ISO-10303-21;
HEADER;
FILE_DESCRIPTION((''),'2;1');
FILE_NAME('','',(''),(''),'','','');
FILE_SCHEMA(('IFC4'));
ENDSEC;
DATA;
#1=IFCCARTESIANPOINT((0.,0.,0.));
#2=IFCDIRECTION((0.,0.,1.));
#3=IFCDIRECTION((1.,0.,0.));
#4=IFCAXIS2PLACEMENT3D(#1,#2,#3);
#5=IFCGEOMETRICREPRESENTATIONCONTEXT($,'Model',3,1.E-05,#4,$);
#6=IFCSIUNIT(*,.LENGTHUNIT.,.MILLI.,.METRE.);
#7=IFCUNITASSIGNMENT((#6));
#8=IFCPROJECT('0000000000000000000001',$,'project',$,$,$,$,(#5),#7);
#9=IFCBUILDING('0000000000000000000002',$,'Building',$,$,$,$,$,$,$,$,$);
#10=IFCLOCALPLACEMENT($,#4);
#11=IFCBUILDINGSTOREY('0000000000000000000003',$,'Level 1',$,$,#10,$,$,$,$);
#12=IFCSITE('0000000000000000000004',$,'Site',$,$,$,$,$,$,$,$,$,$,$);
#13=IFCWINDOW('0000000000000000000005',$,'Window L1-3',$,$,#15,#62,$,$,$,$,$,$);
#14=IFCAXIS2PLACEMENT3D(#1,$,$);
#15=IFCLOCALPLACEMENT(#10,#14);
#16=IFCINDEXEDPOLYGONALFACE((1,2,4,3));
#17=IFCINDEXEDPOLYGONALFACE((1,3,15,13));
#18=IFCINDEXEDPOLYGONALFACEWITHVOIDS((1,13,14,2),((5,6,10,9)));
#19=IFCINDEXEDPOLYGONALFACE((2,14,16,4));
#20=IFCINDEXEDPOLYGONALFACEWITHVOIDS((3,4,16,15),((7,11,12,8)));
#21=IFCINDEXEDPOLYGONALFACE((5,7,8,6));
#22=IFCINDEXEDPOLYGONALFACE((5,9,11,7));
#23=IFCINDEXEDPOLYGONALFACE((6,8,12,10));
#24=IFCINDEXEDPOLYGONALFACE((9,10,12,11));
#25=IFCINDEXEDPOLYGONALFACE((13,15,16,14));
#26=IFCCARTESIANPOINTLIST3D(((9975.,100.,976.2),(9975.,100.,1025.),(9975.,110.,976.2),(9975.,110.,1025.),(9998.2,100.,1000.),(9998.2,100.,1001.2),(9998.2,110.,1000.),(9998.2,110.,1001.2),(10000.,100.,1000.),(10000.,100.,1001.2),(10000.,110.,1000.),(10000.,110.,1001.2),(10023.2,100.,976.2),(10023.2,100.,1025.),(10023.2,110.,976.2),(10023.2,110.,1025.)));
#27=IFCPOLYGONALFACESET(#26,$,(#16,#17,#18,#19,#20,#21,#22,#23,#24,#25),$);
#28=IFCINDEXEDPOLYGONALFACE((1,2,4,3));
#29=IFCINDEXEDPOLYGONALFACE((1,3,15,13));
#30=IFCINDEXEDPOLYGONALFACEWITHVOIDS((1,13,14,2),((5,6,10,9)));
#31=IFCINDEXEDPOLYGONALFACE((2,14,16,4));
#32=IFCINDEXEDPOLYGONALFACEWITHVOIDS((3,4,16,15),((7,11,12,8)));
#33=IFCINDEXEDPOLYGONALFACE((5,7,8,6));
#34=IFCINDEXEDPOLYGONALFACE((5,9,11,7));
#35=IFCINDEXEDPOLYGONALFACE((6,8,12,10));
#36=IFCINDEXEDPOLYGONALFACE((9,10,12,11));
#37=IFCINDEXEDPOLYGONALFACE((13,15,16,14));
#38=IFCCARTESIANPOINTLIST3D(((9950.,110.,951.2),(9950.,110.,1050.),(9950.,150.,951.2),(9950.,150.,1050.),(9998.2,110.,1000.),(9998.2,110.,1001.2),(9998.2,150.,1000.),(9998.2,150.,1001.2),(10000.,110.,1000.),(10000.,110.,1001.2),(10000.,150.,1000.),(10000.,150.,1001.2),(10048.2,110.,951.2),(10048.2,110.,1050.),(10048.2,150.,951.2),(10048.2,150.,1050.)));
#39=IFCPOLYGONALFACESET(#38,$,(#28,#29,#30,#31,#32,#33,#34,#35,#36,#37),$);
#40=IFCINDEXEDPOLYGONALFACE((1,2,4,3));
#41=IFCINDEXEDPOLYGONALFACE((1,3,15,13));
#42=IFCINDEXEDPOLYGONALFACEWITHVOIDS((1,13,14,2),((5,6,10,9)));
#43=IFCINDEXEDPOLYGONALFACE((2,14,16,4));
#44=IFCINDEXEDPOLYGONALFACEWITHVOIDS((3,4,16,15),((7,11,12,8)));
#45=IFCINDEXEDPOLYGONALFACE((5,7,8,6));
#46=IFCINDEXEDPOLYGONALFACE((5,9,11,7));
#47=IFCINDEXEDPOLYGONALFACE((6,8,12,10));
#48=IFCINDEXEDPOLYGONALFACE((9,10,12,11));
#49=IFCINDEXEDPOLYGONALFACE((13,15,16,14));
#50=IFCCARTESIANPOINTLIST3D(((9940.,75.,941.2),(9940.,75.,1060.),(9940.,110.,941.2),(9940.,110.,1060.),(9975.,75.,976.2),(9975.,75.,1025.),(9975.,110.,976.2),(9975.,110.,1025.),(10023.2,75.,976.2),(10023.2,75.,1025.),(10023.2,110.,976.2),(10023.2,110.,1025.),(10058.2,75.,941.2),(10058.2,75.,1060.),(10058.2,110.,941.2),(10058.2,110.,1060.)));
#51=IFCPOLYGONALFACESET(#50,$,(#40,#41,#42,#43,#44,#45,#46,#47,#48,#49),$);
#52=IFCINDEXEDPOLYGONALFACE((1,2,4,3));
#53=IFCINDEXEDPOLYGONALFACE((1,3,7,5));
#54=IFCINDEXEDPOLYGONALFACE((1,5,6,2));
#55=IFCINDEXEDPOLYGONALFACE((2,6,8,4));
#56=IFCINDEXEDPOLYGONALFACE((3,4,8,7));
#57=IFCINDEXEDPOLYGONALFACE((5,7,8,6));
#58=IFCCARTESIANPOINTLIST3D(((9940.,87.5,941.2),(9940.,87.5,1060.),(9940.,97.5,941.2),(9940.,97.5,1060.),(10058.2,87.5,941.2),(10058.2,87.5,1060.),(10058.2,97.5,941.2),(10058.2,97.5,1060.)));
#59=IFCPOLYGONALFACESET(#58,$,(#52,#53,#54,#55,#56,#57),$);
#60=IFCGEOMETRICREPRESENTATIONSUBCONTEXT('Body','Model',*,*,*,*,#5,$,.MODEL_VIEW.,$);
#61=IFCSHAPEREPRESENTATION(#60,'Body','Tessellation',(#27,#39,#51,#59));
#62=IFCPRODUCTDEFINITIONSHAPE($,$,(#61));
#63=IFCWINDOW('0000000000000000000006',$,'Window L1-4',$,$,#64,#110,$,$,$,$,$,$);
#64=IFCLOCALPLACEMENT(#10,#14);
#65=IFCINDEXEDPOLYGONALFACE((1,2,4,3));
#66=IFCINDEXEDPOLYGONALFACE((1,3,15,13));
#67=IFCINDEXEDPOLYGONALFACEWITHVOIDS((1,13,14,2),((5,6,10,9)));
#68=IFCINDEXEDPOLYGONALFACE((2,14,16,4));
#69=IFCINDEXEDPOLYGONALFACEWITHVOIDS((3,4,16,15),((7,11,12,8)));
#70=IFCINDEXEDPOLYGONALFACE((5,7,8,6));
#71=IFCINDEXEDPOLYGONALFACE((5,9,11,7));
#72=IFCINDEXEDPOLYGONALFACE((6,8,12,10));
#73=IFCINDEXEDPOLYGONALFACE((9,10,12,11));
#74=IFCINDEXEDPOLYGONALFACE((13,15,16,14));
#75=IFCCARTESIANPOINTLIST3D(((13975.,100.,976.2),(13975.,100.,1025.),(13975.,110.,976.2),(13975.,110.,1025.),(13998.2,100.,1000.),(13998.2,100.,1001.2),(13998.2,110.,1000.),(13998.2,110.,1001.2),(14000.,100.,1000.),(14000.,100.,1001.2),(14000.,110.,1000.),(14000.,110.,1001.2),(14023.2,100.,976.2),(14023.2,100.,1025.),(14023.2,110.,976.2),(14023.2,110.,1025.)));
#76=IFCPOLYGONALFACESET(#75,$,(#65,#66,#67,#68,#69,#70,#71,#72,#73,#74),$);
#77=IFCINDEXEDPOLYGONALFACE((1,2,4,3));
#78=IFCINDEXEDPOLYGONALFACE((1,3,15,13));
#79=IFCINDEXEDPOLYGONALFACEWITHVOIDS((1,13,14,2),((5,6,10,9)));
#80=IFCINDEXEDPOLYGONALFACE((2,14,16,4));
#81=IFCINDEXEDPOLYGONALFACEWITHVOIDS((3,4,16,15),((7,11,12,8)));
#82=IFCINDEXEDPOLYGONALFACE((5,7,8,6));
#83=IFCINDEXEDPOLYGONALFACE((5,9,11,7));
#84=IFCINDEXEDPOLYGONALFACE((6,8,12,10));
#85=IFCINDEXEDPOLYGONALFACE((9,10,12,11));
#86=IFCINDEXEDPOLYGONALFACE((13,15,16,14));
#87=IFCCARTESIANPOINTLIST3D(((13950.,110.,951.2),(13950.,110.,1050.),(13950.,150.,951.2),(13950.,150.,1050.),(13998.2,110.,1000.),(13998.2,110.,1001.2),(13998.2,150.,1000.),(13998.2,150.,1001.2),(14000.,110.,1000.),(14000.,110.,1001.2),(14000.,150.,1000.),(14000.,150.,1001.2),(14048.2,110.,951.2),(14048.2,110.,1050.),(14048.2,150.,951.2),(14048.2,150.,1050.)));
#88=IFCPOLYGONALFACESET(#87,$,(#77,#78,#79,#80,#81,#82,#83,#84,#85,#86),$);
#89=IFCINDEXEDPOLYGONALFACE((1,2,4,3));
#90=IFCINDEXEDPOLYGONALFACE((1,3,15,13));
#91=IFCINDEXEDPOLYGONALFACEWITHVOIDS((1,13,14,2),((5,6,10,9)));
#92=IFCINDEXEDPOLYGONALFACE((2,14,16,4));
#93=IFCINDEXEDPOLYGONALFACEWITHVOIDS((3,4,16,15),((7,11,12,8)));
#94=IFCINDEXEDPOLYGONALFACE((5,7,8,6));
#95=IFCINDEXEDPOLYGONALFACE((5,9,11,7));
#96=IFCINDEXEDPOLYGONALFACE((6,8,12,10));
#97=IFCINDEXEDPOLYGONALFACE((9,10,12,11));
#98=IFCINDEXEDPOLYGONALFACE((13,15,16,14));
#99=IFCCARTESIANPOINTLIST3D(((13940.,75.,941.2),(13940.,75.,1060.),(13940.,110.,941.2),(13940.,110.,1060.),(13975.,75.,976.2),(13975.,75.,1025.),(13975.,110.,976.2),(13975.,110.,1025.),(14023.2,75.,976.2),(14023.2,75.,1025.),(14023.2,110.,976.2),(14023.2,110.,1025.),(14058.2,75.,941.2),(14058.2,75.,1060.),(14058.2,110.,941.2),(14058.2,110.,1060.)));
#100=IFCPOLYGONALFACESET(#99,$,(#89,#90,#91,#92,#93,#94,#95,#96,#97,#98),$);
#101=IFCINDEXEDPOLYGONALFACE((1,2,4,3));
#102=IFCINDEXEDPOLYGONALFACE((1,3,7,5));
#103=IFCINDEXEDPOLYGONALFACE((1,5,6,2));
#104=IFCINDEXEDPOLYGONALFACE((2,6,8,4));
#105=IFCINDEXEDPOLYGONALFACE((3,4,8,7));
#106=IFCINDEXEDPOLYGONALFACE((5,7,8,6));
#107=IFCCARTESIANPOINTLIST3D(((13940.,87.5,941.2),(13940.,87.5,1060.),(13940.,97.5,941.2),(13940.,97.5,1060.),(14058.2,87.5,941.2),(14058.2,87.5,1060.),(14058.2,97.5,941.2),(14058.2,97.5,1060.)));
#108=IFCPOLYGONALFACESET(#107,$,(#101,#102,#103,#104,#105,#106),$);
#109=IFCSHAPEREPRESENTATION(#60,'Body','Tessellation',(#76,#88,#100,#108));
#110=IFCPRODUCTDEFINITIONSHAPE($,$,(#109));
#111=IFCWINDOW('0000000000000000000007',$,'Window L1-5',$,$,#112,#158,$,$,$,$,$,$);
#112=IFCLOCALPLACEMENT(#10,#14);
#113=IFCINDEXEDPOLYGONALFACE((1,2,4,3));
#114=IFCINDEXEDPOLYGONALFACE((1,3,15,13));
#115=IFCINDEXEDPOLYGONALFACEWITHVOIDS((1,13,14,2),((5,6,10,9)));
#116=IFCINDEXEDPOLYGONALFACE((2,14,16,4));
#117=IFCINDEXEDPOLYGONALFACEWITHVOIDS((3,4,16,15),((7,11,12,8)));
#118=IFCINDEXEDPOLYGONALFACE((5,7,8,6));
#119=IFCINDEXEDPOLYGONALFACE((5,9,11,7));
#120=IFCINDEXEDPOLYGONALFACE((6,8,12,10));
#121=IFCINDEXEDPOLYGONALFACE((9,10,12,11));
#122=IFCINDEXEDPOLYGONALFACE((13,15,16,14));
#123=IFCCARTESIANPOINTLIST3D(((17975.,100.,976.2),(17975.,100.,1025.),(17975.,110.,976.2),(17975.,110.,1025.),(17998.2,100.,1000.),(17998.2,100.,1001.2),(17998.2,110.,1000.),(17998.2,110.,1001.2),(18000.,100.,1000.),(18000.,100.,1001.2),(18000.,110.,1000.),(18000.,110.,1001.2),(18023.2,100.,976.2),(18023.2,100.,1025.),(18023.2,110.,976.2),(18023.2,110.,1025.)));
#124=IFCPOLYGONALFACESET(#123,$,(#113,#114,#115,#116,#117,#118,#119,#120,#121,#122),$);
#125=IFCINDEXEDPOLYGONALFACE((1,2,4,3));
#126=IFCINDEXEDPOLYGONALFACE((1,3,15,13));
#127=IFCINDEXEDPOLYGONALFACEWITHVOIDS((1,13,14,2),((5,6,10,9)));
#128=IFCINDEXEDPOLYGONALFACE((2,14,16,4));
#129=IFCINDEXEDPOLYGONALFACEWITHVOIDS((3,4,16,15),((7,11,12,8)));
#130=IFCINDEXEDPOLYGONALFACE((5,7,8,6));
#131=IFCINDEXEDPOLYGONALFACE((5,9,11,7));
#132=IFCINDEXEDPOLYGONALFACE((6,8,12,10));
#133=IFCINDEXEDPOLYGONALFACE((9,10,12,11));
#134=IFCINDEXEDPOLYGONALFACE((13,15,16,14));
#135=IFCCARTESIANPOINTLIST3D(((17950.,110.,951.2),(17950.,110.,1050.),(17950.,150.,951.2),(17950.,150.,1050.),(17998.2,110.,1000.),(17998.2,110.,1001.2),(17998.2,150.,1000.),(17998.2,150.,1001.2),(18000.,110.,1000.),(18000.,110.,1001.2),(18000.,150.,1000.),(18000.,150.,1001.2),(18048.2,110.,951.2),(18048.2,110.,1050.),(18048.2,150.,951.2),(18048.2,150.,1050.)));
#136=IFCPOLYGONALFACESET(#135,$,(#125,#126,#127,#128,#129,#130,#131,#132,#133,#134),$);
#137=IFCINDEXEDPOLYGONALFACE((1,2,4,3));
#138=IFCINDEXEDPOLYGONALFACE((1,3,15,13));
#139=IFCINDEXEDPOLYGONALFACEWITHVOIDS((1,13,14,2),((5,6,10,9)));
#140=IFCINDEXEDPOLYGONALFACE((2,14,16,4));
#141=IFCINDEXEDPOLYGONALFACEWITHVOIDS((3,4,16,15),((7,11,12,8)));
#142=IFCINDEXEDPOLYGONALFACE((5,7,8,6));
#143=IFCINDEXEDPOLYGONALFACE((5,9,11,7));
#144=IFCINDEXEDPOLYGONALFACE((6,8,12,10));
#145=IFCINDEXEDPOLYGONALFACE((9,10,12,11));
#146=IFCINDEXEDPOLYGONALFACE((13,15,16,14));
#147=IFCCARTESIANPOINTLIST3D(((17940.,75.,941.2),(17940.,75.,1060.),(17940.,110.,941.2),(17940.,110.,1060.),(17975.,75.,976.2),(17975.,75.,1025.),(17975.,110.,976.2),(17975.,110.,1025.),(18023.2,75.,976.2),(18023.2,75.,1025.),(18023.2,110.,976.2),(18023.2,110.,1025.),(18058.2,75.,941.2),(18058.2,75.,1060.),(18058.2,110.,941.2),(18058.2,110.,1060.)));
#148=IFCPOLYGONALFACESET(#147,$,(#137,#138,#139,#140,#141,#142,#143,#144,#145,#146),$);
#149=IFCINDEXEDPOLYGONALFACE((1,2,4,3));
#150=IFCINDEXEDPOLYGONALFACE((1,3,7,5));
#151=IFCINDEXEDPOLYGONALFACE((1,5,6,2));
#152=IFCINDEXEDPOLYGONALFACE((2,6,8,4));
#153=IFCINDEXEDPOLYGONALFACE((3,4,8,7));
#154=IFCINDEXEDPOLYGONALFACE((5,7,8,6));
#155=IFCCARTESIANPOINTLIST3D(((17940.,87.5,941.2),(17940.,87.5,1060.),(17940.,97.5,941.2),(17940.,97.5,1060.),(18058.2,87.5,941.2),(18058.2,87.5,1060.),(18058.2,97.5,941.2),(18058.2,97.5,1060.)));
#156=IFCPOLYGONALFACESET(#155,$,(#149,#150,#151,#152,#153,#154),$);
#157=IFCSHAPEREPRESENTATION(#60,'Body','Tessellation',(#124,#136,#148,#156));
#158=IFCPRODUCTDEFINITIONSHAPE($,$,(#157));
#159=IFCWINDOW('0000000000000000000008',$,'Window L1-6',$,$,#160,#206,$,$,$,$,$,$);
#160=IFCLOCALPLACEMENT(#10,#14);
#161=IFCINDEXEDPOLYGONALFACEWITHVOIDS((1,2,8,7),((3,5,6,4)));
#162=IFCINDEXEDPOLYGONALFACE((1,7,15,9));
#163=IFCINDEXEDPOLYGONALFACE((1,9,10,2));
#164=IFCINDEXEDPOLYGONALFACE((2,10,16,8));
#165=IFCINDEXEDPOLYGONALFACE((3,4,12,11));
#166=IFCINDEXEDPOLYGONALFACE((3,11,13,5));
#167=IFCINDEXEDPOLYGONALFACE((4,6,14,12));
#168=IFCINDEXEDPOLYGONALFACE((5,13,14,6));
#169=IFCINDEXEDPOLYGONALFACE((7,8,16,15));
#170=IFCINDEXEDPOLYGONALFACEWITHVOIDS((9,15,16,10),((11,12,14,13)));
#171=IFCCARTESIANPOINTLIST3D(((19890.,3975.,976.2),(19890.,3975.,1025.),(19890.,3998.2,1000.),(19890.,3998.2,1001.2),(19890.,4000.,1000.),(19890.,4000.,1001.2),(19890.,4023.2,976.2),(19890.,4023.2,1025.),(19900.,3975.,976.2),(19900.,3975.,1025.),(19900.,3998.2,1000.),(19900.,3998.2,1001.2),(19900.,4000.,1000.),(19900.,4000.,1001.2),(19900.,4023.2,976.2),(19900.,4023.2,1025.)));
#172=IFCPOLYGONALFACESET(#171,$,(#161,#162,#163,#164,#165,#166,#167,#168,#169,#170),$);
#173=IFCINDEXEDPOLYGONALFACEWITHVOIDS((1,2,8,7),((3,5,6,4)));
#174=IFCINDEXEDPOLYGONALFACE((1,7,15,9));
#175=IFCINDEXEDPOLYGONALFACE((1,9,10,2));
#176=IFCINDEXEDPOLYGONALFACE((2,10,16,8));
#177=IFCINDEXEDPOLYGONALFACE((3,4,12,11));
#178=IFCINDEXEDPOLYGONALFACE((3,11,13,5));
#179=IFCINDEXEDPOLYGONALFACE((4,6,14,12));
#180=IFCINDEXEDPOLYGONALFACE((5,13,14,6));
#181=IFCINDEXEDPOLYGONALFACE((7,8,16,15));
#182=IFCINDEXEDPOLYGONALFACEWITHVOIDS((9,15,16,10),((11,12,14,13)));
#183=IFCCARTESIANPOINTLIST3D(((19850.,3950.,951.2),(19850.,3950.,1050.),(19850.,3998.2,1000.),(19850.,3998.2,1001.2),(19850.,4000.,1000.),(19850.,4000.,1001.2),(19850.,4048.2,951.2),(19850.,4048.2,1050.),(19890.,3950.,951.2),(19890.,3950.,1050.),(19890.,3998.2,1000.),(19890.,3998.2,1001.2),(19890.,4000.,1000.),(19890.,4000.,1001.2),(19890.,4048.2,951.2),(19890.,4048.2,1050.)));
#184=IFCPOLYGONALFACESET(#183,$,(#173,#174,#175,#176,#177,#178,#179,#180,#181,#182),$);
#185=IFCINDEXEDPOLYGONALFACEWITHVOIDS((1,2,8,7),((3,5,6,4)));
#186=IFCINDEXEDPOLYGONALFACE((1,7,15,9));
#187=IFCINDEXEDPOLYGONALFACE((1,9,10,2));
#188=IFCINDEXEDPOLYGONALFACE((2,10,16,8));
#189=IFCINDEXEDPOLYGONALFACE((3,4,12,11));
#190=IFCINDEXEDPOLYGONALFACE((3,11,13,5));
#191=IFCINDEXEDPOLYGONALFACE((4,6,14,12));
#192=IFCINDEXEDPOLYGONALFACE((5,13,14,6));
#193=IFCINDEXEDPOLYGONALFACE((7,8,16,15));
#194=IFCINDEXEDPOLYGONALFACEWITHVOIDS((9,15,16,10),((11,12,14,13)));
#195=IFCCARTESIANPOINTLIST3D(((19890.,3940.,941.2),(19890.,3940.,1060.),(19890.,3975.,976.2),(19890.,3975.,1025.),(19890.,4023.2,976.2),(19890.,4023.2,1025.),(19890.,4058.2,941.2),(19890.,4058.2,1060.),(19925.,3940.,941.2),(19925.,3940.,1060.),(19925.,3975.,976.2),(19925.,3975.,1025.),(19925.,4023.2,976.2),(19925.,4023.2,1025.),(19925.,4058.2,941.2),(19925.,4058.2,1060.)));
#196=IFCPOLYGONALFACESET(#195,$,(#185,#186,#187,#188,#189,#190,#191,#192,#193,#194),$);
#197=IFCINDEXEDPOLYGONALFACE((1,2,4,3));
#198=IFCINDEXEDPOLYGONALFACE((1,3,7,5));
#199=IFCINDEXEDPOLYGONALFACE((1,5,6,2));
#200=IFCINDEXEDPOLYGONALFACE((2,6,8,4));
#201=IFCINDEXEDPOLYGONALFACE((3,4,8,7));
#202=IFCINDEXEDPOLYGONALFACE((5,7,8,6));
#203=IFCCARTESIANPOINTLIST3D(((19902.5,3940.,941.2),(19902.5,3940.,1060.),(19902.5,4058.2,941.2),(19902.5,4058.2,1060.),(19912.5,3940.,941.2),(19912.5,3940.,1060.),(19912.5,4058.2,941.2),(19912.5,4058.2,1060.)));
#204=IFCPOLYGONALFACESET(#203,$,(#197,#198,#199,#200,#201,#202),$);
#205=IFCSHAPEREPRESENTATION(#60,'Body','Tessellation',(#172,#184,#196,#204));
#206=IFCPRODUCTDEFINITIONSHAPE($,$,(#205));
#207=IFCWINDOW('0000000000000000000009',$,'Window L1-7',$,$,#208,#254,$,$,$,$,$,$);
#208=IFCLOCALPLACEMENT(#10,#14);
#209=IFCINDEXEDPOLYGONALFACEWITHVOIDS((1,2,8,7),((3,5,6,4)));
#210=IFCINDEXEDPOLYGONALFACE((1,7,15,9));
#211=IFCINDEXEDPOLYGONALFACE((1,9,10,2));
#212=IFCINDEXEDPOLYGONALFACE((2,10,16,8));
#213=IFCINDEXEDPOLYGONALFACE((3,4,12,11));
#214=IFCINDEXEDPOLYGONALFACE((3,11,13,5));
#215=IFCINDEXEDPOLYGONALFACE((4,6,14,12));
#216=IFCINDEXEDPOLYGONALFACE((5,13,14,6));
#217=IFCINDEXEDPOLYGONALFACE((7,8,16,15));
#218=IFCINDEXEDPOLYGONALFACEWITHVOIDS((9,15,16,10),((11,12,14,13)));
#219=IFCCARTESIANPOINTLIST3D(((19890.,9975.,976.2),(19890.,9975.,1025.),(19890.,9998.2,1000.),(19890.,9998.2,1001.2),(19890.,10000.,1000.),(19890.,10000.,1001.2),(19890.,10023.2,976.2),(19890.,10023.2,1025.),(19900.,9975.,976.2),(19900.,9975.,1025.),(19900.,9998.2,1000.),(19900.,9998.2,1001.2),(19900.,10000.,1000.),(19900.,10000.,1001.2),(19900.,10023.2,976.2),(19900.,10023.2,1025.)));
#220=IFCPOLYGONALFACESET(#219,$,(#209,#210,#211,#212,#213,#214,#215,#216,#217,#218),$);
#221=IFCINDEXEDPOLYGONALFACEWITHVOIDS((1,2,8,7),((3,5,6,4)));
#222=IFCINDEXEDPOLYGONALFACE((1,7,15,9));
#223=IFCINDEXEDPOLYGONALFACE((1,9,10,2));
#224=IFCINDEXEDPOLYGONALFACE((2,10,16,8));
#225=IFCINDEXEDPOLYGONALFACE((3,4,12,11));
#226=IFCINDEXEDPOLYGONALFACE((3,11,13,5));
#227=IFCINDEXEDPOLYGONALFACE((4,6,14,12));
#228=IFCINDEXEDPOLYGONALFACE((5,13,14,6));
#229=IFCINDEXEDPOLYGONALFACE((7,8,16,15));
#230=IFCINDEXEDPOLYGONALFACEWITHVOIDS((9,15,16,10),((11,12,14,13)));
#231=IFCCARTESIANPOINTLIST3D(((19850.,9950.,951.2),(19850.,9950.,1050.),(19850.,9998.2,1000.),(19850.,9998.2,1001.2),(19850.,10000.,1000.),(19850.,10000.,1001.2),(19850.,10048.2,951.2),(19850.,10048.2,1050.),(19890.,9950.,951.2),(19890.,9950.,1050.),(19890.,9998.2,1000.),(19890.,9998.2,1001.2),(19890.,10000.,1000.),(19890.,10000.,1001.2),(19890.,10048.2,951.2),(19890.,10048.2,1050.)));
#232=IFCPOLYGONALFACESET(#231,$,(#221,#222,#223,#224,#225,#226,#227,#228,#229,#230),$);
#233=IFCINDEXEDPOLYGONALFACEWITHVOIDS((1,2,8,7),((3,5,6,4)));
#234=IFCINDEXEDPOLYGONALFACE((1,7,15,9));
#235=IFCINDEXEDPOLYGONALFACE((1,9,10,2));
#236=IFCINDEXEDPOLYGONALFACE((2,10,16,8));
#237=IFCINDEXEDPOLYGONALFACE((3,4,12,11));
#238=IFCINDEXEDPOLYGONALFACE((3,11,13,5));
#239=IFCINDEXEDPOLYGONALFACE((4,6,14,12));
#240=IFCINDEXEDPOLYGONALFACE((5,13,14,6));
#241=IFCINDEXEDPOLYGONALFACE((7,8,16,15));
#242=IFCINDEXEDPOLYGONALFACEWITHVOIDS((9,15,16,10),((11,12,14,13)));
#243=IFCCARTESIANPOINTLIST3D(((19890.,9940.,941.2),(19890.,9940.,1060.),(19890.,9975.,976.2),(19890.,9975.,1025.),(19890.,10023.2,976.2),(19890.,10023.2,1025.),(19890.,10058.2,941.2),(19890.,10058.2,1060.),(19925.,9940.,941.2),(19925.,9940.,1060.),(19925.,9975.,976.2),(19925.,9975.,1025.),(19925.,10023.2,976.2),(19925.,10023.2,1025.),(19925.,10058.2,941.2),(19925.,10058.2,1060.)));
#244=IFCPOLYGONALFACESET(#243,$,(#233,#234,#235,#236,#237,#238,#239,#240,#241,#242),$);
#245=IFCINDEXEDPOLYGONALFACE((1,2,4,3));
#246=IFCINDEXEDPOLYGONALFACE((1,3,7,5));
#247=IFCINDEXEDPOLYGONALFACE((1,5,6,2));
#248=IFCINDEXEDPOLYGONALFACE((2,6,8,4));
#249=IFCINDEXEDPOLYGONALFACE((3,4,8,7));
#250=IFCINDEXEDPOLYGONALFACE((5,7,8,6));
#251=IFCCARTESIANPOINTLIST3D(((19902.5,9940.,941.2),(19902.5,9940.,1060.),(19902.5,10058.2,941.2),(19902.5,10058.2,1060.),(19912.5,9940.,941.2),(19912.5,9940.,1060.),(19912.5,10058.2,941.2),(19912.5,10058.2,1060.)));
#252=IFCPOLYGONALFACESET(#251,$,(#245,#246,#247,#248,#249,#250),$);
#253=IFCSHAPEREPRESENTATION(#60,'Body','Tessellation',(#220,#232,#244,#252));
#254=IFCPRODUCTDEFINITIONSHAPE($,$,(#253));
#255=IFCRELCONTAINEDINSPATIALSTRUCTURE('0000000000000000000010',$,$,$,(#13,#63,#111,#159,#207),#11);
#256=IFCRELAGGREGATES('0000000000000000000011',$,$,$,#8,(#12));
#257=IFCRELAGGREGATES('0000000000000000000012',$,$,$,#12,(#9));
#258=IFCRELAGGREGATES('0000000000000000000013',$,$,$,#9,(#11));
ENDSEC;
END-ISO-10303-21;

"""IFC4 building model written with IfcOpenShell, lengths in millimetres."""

from ifc_helpers import new_model, si_unit, frame, origin_with_axes, place, context, subcontext, project, spatial, line, indexed_curve, outline, extrude, element, save


model = new_model("IFC4")

# Units and contexts
model_context = context("Model", 3, precision=1e-05, world=origin_with_axes())
body_context = subcontext(model_context, "Body", "Model", "MODEL_VIEW")
ifc_project = project(units=[si_unit("LENGTHUNIT", "METRE", prefix="MILLI")], contexts=[model_context])

# Site, building, storey
site = spatial("IfcSite", under=ifc_project, Name="Site")
building = spatial("IfcBuilding", under=site, Name="Building")
storey_placement = place(None, origin_with_axes())
storey = spatial("IfcBuildingStorey", under=building, at=storey_placement, Name="Level 1")

# Windows
for number, where, z_axis, x_axis, name in (
    (1, (10000.0, 200.0, 1000.0), (0.0, 0.0, 1.0), (-1.0, 0.0, 0.0), "Window L1-3"),
    (2, (14000.0, 200.0, 1000.0), (0.0, 0.0, 1.0), (-1.0, 0.0, 0.0), "Window L1-4"),
    (3, (18000.0, 200.0, 1000.0), (0.0, 0.0, 1.0), (-1.0, 0.0, 0.0), "Window L1-5"),
    (4, (19800.0, 4000.0, 1000.0), (0.0, 0.0, 1.0), (0.0, -1.0, 0.0), "Window L1-6"),
    (5, (19800.0, 10000.0, 1000.0), (0.0, 0.0, 1.0), (0.0, -1.0, 0.0), "Window L1-7"),
):
    element("IfcWindow", number, at=place(storey_placement, frame(where, z_axis=z_axis, x_axis=x_axis)), inside=storey, Name=name, context=body_context, shape_type="SweptSolid", body=[
        extrude(outline(indexed_curve([(0.0, 0.0), (1.8, 0.0), (1.8, 1.2), (0.0, 1.2)], segments=[line(1, 2, 3, 4, 1)]), holes=[indexed_curve([(25.0, 25.0), (-23.2, 25.0), (-23.2, -23.8), (25.0, -23.8)], segments=[line(1, 2, 3, 4, 1)])]), frame((0.0, 90.0, 0.0), z_axis=(0.0, -1.0, 0.0), x_axis=(1.0, 0.0, 0.0)), (0.0, 0.0, -1.0), 10.0),
        extrude(outline(indexed_curve([(0.0, 0.0), (1.8, 0.0), (1.8, 1.2), (0.0, 1.2)], segments=[line(1, 2, 3, 4, 1)]), holes=[indexed_curve([(50.0, 50.0), (-48.2, 50.0), (-48.2, -48.8), (50.0, -48.8)], segments=[line(1, 2, 3, 4, 1)])]), frame((0.0, 50.0, 0.0), z_axis=(0.0, -1.0, 0.0), x_axis=(1.0, 0.0, 0.0)), (0.0, 0.0, -1.0), 40.0),
        extrude(outline(indexed_curve([(0.0, 0.0), (-48.2, 0.0), (-48.2, -48.8), (0.0, -48.8)], segments=[line(1, 2, 3, 4, 1)]), holes=[indexed_curve([(35.0, 35.0), (-83.2, 35.0), (-83.2, -83.8), (35.0, -83.8)], segments=[line(1, 2, 3, 4, 1)])]), frame((25.0, 90.0, 25.0), z_axis=(0.0, -1.0, 0.0), x_axis=(1.0, 0.0, 0.0)), (0.0, 0.0, -1.0), 35.0),
        extrude(outline(indexed_curve([(35.0, 35.0), (-83.2, 35.0), (-83.2, -83.8), (35.0, -83.8)], segments=[line(1, 2, 3, 4, 1)])), frame((25.0, 102.5, 25.0), z_axis=(0.0, -1.0, 0.0), x_axis=(1.0, 0.0, 0.0)), (0.0, 0.0, -1.0), 10.0),
    ])

save(model, "model.ifc")
